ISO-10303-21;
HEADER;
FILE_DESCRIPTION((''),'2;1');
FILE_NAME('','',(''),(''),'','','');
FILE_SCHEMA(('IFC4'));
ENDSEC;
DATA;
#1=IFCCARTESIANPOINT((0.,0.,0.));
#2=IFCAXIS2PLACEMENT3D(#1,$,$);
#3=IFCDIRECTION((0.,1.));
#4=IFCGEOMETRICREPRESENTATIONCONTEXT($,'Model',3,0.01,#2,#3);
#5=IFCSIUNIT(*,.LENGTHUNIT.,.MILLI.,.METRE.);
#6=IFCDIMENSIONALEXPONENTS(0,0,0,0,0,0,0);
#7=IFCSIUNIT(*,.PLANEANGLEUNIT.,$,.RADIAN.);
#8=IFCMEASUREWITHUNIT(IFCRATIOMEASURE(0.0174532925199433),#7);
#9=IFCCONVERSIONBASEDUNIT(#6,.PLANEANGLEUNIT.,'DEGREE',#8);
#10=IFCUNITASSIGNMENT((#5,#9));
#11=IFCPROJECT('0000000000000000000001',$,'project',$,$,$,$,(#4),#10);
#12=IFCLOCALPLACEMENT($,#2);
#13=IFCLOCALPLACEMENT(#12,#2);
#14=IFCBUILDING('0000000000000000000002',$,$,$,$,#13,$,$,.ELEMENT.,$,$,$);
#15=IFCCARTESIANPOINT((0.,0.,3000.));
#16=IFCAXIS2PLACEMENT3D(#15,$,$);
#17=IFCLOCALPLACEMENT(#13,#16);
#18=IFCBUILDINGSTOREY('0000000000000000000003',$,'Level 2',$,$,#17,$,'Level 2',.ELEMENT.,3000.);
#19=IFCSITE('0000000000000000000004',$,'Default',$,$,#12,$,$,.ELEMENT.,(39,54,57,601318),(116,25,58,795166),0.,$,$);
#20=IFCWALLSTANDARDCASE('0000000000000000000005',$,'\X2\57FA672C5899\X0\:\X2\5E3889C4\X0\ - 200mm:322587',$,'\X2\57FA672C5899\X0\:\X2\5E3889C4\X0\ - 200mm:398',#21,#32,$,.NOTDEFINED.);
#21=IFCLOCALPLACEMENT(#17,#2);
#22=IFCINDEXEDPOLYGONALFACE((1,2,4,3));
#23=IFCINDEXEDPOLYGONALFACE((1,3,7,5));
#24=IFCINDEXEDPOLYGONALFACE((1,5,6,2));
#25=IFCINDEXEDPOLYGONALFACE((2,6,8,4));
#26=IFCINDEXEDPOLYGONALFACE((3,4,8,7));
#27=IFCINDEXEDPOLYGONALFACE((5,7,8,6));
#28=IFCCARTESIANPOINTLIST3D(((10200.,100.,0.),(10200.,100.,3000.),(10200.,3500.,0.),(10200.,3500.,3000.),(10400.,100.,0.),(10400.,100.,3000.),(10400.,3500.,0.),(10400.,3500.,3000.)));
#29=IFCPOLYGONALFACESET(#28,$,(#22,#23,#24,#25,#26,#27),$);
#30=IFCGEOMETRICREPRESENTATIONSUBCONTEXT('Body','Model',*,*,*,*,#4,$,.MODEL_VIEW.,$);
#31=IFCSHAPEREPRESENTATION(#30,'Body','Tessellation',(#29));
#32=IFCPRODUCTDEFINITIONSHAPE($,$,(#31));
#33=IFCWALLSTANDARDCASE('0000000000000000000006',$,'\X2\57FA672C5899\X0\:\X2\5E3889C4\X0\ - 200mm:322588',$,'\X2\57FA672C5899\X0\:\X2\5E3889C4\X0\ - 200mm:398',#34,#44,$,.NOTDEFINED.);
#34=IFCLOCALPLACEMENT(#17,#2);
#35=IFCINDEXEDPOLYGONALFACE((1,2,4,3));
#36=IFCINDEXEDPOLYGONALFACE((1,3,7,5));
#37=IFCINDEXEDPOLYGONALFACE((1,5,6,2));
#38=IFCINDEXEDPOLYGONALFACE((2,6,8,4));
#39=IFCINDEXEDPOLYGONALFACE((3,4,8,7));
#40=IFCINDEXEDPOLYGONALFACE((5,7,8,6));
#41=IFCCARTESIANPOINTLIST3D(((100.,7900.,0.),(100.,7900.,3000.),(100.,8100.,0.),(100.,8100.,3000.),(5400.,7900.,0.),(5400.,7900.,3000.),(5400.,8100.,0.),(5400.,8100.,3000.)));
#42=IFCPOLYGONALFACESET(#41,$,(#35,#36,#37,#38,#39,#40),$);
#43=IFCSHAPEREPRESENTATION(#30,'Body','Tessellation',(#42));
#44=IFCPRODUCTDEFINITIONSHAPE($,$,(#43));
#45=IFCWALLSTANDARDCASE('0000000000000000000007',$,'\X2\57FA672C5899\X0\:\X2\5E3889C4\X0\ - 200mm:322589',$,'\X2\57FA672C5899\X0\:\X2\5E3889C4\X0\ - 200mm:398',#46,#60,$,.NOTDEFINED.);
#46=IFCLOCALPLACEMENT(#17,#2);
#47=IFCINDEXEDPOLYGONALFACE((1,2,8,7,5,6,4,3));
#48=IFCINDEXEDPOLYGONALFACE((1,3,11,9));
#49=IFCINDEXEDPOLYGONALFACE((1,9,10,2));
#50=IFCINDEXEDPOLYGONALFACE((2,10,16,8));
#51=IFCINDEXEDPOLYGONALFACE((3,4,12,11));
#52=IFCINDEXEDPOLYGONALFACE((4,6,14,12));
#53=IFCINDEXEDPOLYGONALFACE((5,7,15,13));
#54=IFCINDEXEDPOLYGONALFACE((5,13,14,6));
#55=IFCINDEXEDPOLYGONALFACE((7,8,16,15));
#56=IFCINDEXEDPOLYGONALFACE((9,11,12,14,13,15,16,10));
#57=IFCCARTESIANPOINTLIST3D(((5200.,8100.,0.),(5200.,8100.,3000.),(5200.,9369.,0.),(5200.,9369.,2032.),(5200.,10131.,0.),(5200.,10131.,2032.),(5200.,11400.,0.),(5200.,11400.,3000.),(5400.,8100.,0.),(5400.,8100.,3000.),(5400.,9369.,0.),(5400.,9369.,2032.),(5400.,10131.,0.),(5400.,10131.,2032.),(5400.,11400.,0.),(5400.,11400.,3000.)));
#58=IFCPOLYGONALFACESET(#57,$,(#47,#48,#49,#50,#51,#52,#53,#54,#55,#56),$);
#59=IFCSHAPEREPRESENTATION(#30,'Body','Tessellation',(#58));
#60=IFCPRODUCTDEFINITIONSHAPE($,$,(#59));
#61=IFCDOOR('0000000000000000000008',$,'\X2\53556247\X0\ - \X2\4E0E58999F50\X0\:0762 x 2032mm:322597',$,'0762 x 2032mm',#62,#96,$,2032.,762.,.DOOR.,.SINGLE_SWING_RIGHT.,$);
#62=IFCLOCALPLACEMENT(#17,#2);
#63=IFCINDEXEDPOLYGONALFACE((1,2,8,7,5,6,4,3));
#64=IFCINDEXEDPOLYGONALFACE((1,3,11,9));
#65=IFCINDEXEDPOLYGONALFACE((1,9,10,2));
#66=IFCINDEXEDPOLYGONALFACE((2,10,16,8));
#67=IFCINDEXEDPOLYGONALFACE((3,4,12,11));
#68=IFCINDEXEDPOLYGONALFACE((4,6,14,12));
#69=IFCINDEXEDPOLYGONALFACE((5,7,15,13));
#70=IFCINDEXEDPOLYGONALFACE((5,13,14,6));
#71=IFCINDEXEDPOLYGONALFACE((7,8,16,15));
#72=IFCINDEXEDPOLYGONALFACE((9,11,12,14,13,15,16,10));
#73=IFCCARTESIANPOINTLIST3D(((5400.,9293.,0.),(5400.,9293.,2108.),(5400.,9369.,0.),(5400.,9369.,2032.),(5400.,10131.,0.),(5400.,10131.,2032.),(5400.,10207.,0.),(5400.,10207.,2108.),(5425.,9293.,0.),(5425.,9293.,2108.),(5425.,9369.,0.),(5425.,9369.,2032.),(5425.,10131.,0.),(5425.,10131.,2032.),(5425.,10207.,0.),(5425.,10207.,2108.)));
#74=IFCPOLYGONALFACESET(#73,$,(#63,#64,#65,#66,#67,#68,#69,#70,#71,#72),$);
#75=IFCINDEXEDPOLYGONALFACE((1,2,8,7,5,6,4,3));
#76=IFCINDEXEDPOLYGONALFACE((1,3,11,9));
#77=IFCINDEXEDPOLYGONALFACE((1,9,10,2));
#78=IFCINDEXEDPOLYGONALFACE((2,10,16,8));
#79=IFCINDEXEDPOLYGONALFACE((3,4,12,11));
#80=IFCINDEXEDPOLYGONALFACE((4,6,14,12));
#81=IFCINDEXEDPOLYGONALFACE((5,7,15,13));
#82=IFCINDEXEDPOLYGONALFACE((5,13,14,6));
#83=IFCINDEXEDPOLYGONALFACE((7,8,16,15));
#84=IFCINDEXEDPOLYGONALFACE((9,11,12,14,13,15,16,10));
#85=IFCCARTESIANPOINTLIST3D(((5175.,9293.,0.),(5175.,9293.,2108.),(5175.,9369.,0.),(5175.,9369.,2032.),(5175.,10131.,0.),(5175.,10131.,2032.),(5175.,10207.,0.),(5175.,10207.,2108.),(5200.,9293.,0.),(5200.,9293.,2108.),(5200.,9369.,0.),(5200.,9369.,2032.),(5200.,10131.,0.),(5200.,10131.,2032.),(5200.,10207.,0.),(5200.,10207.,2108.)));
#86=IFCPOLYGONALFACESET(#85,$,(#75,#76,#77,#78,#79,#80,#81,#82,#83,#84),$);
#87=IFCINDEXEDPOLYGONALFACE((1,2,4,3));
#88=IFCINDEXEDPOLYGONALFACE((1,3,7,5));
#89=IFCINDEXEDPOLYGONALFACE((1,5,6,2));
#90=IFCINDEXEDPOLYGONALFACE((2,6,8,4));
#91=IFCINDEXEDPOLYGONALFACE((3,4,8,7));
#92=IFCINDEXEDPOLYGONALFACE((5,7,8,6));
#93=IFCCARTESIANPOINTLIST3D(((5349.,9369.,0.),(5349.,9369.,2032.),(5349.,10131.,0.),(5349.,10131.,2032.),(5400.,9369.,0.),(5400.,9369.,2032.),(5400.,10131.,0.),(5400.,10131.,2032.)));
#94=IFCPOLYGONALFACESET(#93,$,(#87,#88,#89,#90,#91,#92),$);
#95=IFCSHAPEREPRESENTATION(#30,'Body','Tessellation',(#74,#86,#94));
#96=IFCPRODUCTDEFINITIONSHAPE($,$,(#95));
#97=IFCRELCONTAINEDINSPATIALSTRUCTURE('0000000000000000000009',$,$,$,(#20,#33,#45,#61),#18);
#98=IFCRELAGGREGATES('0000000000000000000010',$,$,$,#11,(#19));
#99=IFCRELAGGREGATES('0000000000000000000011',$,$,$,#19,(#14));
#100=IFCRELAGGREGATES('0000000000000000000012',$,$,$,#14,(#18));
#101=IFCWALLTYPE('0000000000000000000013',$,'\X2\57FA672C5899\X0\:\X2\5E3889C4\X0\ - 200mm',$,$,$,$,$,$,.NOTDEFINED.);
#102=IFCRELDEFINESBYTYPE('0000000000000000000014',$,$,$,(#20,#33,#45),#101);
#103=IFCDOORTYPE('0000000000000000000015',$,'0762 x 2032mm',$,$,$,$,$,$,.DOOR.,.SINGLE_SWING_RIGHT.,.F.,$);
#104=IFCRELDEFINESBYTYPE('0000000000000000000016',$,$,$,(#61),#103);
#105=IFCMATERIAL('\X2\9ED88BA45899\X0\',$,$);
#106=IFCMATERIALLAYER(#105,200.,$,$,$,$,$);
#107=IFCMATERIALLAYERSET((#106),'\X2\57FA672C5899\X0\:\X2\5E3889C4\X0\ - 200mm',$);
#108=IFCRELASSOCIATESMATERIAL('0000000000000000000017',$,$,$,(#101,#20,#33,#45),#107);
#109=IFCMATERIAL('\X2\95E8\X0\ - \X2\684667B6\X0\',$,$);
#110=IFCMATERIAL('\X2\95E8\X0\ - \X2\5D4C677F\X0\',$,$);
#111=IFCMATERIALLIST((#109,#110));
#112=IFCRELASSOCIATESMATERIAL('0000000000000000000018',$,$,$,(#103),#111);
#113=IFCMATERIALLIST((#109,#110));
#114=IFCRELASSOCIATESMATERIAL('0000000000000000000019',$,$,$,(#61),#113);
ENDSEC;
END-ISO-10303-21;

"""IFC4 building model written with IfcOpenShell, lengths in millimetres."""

from ifc_helpers import new_model, entity, si_unit, converted_unit, direction, frame, frame_2d, origin, origin_2d_with_axis, place, context, subcontext, project, spatial, polyline, rectangle, outline, extrude, source, transform, mapped, material, material_list, layer, layer_set, layer_usage, type_object, type_shapes, element, fill, save


model = new_model("IFC4")

# Units and contexts
model_context = context("Model", 3, precision=0.01, world=origin(), true_north=direction((0.0, 1.0)))
body_context = subcontext(model_context, "Body", "Model", "MODEL_VIEW")
ifc_project = project(units=[si_unit("LENGTHUNIT", "METRE", prefix="MILLI"), converted_unit("PLANEANGLEUNIT", "DEGREE", entity("IfcRatioMeasure", 0.0174532925199433), si_unit("PLANEANGLEUNIT", "RADIAN"), dimensions=[0, 0, 0, 0, 0, 0, 0])], contexts=[model_context])

# Site, building, storey
site_placement = place(None, origin())
site = spatial("IfcSite", under=ifc_project, at=site_placement, Name="Default", CompositionType="ELEMENT", RefLatitude=(39, 54, 57, 601318), RefLongitude=(116, 25, 58, 795166), RefElevation=0.0)
building_placement = place(site_placement, origin())
building = spatial("IfcBuilding", under=site, at=building_placement, CompositionType="ELEMENT")
storey_placement = place(building_placement, frame((0.0, 0.0, 3000.0)))
storey = spatial("IfcBuildingStorey", under=building, at=storey_placement, Name="Level 2", LongName="Level 2", CompositionType="ELEMENT", Elevation=3000.0)

# Shared definitions
ifc_material_1 = material(Name="默认墙")
ifc_layer_1 = layer(ifc_material_1, 200.0)
ifc_layer_set_1 = layer_set([ifc_layer_1], Name="基本墙:常规 - 200mm")
wall_type = type_object("IfcWallType", Name="基本墙:常规 - 200mm", PredefinedType="NOTDEFINED", material=ifc_layer_set_1)

# Shared definitions
ifc_material_2 = material(Name="门 - 框架")
ifc_material_3 = material(Name="门 - 嵌板")
ifc_material_list_1 = material_list([ifc_material_2, ifc_material_3])
door_type_1 = type_object("IfcDoorType", Name="0762 x 2032mm", OperationType="SINGLE_SWING_RIGHT", ParameterTakesPrecedence=False, PredefinedType="DOOR", material=ifc_material_list_1)
shared_shape_1 = source(origin(), body_context, "Body", "SweptSolid", [
    extrude(outline(polyline([(-457.0, -1073.0), (457.0, -1073.0), (457.0, 1035.0), (381.0, 1035.0), (381.0, -997.0), (-381.0, -997.0), (-381.0, 1035.0), (-457.0, 1035.0), (-457.0, -1073.0)])), frame((381.0, 200.0, 1035.0), z_axis=(0.0, 1.0, 0.0), x_axis=(1.0, 0.0, 0.0)), (0.0, 0.0, 1.0), 25.0),
    extrude(outline(polyline([(-1073.0, -457.0), (1035.0, -457.0), (1035.0, -381.0), (-997.0, -381.0), (-997.0, 381.0), (1035.0, 381.0), (1035.0, 457.0), (-1073.0, 457.0), (-1073.0, -457.0)])), frame((381.0, -25.0, 1035.0), z_axis=(0.0, 1.0, 0.0), x_axis=(0.0, 0.0, -1.0)), (0.0, 0.0, 1.0), 25.0),
    extrude(rectangle(XDim=51.0, YDim=762.0, at=origin_2d_with_axis()), frame((381.0, 174.5, 0.0), z_axis=(0.0, 0.0, 1.0), x_axis=(0.0, 1.0, 0.0)), (0.0, 0.0, 1.0), 2032.0),
])
type_shapes(door_type_1, [shared_shape_1])

# Walls
ifc_layer_usage_1 = layer_usage(ifc_layer_set_1, "AXIS2", "NEGATIVE", 100.0)
wall_1_placement = place(storey_placement, frame((10300.0, 3500.0, 0.0), z_axis=(0.0, 0.0, 1.0), x_axis=(0.0, -1.0, 0.0)))
element("IfcWallStandardCase", 1, at=wall_1_placement, inside=storey, type_object=wall_type, material=ifc_layer_usage_1, Name="基本墙:常规 - 200mm:322587", ObjectType="基本墙:常规 - 200mm:398", PredefinedType="NOTDEFINED", context=body_context, shape_type="SweptSolid", body=[
    extrude(rectangle(XDim=3400.0, YDim=200.0, at=frame_2d((1700.0, 0.0), x_axis=(-1.0, 0.0))), origin(), (0.0, 0.0, 1.0), 3000.0),
])
ifc_layer_usage_2 = layer_usage(ifc_layer_set_1, "AXIS2", "NEGATIVE", 100.0)
wall_2_placement = place(storey_placement, frame((100.0, 8000.0, 0.0)))
element("IfcWallStandardCase", 2, at=wall_2_placement, inside=storey, type_object=wall_type, material=ifc_layer_usage_2, Name="基本墙:常规 - 200mm:322588", ObjectType="基本墙:常规 - 200mm:398", PredefinedType="NOTDEFINED", context=body_context, shape_type="SweptSolid", body=[
    extrude(rectangle(XDim=5300.0, YDim=200.0, at=frame_2d((2650.0, 0.0), x_axis=(-1.0, 0.0))), origin(), (0.0, 0.0, 1.0), 3000.0),
])

# Wall, opening, door
ifc_layer_usage_3 = layer_usage(ifc_layer_set_1, "AXIS2", "NEGATIVE", 100.0)
wall_3_placement = place(storey_placement, frame((5300.0, 8100.0, 0.0), z_axis=(0.0, 0.0, 1.0), x_axis=(0.0, 1.0, 0.0)))
wall_3 = element("IfcWallStandardCase", 3, at=wall_3_placement, inside=storey, type_object=wall_type, material=ifc_layer_usage_3, Name="基本墙:常规 - 200mm:322589", ObjectType="基本墙:常规 - 200mm:398", PredefinedType="NOTDEFINED", context=body_context, shape_type="SweptSolid", body=[
    extrude(rectangle(XDim=3300.0, YDim=200.0, at=frame_2d((1650.0, 0.0), x_axis=(-1.0, 0.0))), origin(), (0.0, 0.0, 1.0), 3000.0),
])
opening_1_placement = place(wall_3_placement, frame((2031.0, 100.0, 0.0)))
opening_1 = element("IfcOpeningElement", 4, at=opening_1_placement, cuts=wall_3, ObjectType="Opening", PredefinedType="OPENING", context=body_context, shape_type="SweptSolid", body=[
    extrude(rectangle(XDim=762.0, YDim=2032.0, at=frame_2d((1016.0, 381.0), x_axis=(0.0, 1.0))), frame((0.0, 0.0, 0.0), z_axis=(0.0, -1.0, 0.0), x_axis=(0.0, 0.0, 1.0)), (0.0, 0.0, 1.0), 200.0),
])
ifc_material_list_2 = material_list([ifc_material_2, ifc_material_3])
door_1_placement = place(opening_1_placement, frame((0.0, 0.0, 0.0), z_axis=(0.0, 0.0, 1.0), x_axis=(-1.0, 0.0, 0.0)))
door_1 = element("IfcDoor", 5, at=door_1_placement, inside=storey, type_object=door_type_1, material=ifc_material_list_2, Name="单扇 - 与墙齐:0762 x 2032mm:322597", ObjectType="0762 x 2032mm", OperationType="SINGLE_SWING_RIGHT", OverallHeight=2032.0, OverallWidth=762.0, PredefinedType="DOOR", context=body_context, shape_type="MappedRepresentation", body=[
    mapped(shared_shape_1, transform((0.0, 0.0, 0.0), scale=1.0)),
])
fill(opening_1, door_1)

save(model, "model.ifc")
